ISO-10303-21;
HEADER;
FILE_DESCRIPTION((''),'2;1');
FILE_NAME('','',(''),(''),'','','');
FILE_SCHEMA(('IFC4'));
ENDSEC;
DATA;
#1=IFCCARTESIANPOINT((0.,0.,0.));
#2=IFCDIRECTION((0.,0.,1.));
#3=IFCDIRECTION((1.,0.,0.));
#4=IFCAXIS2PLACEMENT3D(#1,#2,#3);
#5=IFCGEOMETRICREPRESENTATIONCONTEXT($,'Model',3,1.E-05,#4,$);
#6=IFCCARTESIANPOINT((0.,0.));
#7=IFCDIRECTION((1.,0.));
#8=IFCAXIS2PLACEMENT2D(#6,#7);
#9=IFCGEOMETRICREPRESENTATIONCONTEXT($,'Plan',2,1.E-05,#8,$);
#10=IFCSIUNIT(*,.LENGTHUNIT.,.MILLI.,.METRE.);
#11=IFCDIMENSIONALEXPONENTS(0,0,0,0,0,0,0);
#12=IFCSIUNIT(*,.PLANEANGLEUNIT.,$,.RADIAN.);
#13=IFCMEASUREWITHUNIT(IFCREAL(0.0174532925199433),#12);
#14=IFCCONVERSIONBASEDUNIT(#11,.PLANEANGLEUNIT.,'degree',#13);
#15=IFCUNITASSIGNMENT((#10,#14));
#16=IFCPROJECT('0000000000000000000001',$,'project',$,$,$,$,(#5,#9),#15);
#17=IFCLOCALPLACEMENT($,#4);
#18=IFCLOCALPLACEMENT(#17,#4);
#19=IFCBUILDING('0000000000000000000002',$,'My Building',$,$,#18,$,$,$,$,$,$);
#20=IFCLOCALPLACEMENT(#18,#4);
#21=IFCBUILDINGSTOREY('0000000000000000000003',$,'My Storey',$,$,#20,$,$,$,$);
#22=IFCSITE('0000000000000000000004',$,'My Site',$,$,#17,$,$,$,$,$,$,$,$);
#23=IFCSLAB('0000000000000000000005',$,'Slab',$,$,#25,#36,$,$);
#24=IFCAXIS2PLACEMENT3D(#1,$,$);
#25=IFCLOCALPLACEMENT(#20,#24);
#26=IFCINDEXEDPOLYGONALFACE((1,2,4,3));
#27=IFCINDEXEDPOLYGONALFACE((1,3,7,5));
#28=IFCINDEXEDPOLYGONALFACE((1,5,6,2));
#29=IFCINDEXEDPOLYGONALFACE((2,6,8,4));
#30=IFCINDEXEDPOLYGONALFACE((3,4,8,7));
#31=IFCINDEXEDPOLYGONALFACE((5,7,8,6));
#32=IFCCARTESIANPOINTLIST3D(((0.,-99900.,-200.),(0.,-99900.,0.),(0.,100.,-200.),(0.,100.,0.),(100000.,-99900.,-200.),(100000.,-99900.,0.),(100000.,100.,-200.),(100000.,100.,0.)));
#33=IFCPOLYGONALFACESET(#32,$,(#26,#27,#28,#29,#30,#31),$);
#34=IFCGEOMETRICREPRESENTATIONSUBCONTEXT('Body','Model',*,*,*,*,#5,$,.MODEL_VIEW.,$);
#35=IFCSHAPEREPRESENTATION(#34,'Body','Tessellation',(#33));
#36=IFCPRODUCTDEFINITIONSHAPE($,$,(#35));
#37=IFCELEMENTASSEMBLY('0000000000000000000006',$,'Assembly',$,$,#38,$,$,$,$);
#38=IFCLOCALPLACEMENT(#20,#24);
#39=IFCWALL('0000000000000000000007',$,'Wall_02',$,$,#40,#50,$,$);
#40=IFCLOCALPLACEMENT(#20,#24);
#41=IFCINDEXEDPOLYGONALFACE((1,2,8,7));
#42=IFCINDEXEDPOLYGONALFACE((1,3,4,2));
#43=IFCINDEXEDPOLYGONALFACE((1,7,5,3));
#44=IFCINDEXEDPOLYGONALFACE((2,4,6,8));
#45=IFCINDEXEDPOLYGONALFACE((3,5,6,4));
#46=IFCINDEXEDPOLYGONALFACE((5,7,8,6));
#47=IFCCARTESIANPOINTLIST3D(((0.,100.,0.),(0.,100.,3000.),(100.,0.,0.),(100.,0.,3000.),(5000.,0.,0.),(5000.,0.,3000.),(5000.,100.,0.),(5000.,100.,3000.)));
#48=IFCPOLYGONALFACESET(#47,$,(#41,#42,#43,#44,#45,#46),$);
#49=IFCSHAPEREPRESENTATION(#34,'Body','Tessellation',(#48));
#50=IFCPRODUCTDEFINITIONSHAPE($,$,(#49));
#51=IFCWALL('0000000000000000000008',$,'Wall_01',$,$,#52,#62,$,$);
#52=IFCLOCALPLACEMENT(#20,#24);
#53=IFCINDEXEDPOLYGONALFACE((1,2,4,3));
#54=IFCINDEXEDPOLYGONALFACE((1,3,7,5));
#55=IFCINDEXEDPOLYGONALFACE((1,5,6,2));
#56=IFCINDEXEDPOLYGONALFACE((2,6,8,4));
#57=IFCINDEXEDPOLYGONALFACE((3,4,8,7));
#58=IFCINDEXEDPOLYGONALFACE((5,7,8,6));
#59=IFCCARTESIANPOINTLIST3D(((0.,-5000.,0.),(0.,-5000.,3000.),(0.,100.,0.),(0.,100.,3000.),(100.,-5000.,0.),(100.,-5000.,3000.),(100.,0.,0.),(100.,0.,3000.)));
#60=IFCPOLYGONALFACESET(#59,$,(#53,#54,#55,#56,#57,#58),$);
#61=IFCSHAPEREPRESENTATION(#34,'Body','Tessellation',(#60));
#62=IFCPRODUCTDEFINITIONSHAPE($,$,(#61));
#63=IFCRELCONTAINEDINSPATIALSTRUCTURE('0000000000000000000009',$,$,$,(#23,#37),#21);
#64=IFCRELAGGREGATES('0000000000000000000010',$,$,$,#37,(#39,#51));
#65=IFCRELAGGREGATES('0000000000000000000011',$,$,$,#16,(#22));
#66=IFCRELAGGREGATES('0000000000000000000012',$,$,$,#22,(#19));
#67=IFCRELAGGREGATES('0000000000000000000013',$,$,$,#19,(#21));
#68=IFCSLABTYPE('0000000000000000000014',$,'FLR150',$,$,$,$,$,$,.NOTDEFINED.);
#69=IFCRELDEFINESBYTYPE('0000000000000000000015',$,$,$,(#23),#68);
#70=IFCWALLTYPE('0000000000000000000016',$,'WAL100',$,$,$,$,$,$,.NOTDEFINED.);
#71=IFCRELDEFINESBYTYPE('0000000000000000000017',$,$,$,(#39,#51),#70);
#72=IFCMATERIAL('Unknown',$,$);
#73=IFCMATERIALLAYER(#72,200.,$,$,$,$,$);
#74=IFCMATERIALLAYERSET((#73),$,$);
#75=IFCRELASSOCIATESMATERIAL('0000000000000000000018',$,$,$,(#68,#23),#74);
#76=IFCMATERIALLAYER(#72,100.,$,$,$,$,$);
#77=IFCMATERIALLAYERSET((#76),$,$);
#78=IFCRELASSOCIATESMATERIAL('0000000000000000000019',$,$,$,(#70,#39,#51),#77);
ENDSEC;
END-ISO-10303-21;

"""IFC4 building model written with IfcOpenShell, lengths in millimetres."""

from ifc_helpers import new_model, entity, si_unit, converted_unit, frame, origin_with_axes, origin_2d_with_axis, place, context, subcontext, project, spatial, line, indexed_curve, outline, extrude, material, layer, layer_set, layer_usage, type_object, element, aggregate, save


model = new_model("IFC4")

# Units and contexts
model_context = context("Model", 3, precision=1e-05, world=origin_with_axes())
plan_context = context("Plan", 2, precision=1e-05, world=origin_2d_with_axis())
body_context = subcontext(model_context, "Body", "Model", "MODEL_VIEW")
ifc_project = project(units=[si_unit("LENGTHUNIT", "METRE", prefix="MILLI"), converted_unit("PLANEANGLEUNIT", "degree", entity("IfcReal", 0.0174532925199433), si_unit("PLANEANGLEUNIT", "RADIAN"), dimensions=[0, 0, 0, 0, 0, 0, 0])], contexts=[model_context, plan_context])

# Site, building, storey
site_placement = place(None, origin_with_axes())
site = spatial("IfcSite", under=ifc_project, at=site_placement, Name="My Site")
building_placement = place(site_placement, origin_with_axes())
building = spatial("IfcBuilding", under=site, at=building_placement, Name="My Building")
storey_placement = place(building_placement, origin_with_axes())
storey = spatial("IfcBuildingStorey", under=building, at=storey_placement, Name="My Storey")

# Slab
ifc_material = material(Name="Unknown")
ifc_layer_1 = layer(ifc_material, 200.0)
ifc_layer_set_1 = layer_set([ifc_layer_1])
ifc_layer_usage_1 = layer_usage(ifc_layer_set_1, "AXIS3", "POSITIVE", -200.0)
slab_type = type_object("IfcSlabType", Name="FLR150", PredefinedType="NOTDEFINED", material=ifc_layer_set_1)
slab_placement = place(storey_placement, frame((0.0, 100.0, 0.0), z_axis=(0.0, 0.0, 1.0), x_axis=(1.0, 0.0, 0.0)))
element("IfcSlab", 1, at=slab_placement, inside=storey, type_object=slab_type, material=ifc_layer_usage_1, Name="Slab", context=body_context, shape_type="SweptSolid", body=[
    extrude(outline(indexed_curve([(0.0, 0.0), (0.0, -100000.0), (100000.0, -100000.0), (100000.0, 0.0), (0.0, 0.0)])), frame((0.0, 0.0, -200.0), z_axis=(0.0, 0.0, 1.0), x_axis=(1.0, 0.0, 0.0)), (0.0, 0.0, 1.0), 200.0),
])

# Element assembly, walls
assembly_placement = place(storey_placement, origin_with_axes())
assembly = element("IfcElementAssembly", 2, at=assembly_placement, inside=storey, Name="Assembly")
ifc_layer_2 = layer(ifc_material, 100.0)
ifc_layer_set_2 = layer_set([ifc_layer_2])
ifc_layer_usage_2 = layer_usage(ifc_layer_set_2, "AXIS2", "POSITIVE", 0.0)
wall_type = type_object("IfcWallType", Name="WAL100", PredefinedType="NOTDEFINED", material=ifc_layer_set_2)
wall_1_placement = place(assembly_placement, origin_with_axes())
wall_1 = element("IfcWall", 3, at=wall_1_placement, type_object=wall_type, material=ifc_layer_usage_2, Name="Wall_02", context=body_context, shape_type="SweptSolid", body=[
    extrude(outline(indexed_curve([(100.0, 0.0), (0.0, 100.0), (5000.0, 100.0), (5000.0, 0.0)], segments=[line(1, 2, 3, 4, 1)])), origin_with_axes(), (0.0, 0.0, 1.0), 3000.0),
])
ifc_layer_usage_3 = layer_usage(ifc_layer_set_2, "AXIS2", "POSITIVE", 0.0)
wall_2_placement = place(assembly_placement, frame((0.0, 0.0, 0.0), z_axis=(0.0, 0.0, 1.0), x_axis=(0.0, -1.0, 0.0)))
wall_2 = element("IfcWall", 4, at=wall_2_placement, type_object=wall_type, material=ifc_layer_usage_3, Name="Wall_01", context=body_context, shape_type="SweptSolid", body=[
    extrude(outline(indexed_curve([(-100.0, 0.0), (0.0, 100.0), (5000.0, 100.0), (5000.0, 0.0)], segments=[line(1, 2, 3, 4, 1)])), origin_with_axes(), (0.0, 0.0, 1.0), 3000.0),
])
aggregate(assembly, [wall_1, wall_2])

save(model, "model.ifc")
